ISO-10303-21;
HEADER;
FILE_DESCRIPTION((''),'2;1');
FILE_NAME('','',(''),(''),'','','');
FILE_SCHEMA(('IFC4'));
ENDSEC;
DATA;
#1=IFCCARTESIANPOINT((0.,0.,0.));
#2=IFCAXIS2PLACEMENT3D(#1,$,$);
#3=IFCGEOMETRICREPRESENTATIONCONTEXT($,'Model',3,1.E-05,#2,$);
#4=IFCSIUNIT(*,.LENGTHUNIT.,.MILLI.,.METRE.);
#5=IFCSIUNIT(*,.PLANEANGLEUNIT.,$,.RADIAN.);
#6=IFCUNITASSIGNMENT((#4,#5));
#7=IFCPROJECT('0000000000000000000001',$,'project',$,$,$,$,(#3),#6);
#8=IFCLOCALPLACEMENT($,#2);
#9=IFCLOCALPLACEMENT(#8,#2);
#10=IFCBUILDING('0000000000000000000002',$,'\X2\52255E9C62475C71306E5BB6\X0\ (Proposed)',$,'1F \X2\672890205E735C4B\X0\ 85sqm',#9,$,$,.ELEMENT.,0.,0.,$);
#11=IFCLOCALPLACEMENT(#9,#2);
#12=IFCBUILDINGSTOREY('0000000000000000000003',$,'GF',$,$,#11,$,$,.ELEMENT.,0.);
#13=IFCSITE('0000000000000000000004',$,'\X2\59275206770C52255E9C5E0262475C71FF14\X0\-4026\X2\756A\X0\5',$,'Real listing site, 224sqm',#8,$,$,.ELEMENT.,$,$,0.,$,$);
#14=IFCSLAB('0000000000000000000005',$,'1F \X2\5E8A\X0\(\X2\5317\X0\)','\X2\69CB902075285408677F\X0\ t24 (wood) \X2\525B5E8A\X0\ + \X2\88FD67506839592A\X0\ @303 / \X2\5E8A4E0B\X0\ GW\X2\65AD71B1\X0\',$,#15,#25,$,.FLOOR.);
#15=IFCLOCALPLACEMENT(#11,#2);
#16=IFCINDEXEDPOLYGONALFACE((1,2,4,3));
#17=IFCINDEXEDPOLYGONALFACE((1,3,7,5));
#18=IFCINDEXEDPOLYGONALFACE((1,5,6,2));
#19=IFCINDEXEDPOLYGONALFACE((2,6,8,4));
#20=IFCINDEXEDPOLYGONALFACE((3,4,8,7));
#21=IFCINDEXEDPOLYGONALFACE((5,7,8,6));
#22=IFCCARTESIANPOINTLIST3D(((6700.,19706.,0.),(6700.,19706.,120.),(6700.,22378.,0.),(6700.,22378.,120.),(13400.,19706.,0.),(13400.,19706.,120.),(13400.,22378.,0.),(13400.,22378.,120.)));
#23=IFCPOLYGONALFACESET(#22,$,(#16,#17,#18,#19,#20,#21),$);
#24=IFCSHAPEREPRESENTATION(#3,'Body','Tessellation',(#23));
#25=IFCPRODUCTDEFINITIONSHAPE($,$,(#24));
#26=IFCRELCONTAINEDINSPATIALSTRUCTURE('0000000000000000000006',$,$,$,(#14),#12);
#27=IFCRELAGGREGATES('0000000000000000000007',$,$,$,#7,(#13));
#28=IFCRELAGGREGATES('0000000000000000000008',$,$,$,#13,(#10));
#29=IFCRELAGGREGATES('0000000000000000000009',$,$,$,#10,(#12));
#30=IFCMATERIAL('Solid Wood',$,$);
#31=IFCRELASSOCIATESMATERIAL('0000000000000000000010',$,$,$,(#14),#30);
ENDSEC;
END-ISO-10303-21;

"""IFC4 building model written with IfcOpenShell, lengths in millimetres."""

from ifc_helpers import new_model, si_unit, frame, frame_2d, origin, place, context, project, spatial, rectangle, extrude, material, element, save


model = new_model("IFC4")

# Units and contexts
model_context = context("Model", 3, precision=1e-05, world=origin())
ifc_project = project(units=[si_unit("LENGTHUNIT", "METRE", prefix="MILLI"), si_unit("PLANEANGLEUNIT", "RADIAN")], contexts=[model_context])

# Site, building, storey
site_placement = place(None, origin())
site = spatial("IfcSite", under=ifc_project, at=site_placement, Name="大分県別府市扇山４-4026番5", ObjectType="Real listing site, 224sqm", CompositionType="ELEMENT", RefElevation=0.0)
building_placement = place(site_placement, origin())
building = spatial("IfcBuilding", under=site, at=building_placement, Name="別府扇山の家 (Proposed)", ObjectType="1F 木造平屋 85sqm", CompositionType="ELEMENT", ElevationOfRefHeight=0.0, ElevationOfTerrain=0.0)
storey_placement = place(building_placement, origin())
storey = spatial("IfcBuildingStorey", under=building, at=storey_placement, Name="GF", CompositionType="ELEMENT", Elevation=0.0)

# Slab
ifc_material_1 = material(Name="Solid Wood")
slab_1_placement = place(storey_placement, frame((3350.0, 9853.0, 0.0)))
element("IfcSlab", 1, at=slab_1_placement, inside=storey, material=ifc_material_1, Name="1F 床(北)", Description="構造用合板 t24 (wood) 剛床 + 製材根太 @303 / 床下 GW断熱", PredefinedType="FLOOR", context=model_context, shape_type="SweptSolid", body=[
    extrude(rectangle(XDim=6700.0, YDim=2672.0, at=frame_2d((3350.0, 1336.0))), frame((3350.0, 9853.0, 0.0)), (0.0, 0.0, 1.0), 120.0),
])

save(model, "model.ifc")
